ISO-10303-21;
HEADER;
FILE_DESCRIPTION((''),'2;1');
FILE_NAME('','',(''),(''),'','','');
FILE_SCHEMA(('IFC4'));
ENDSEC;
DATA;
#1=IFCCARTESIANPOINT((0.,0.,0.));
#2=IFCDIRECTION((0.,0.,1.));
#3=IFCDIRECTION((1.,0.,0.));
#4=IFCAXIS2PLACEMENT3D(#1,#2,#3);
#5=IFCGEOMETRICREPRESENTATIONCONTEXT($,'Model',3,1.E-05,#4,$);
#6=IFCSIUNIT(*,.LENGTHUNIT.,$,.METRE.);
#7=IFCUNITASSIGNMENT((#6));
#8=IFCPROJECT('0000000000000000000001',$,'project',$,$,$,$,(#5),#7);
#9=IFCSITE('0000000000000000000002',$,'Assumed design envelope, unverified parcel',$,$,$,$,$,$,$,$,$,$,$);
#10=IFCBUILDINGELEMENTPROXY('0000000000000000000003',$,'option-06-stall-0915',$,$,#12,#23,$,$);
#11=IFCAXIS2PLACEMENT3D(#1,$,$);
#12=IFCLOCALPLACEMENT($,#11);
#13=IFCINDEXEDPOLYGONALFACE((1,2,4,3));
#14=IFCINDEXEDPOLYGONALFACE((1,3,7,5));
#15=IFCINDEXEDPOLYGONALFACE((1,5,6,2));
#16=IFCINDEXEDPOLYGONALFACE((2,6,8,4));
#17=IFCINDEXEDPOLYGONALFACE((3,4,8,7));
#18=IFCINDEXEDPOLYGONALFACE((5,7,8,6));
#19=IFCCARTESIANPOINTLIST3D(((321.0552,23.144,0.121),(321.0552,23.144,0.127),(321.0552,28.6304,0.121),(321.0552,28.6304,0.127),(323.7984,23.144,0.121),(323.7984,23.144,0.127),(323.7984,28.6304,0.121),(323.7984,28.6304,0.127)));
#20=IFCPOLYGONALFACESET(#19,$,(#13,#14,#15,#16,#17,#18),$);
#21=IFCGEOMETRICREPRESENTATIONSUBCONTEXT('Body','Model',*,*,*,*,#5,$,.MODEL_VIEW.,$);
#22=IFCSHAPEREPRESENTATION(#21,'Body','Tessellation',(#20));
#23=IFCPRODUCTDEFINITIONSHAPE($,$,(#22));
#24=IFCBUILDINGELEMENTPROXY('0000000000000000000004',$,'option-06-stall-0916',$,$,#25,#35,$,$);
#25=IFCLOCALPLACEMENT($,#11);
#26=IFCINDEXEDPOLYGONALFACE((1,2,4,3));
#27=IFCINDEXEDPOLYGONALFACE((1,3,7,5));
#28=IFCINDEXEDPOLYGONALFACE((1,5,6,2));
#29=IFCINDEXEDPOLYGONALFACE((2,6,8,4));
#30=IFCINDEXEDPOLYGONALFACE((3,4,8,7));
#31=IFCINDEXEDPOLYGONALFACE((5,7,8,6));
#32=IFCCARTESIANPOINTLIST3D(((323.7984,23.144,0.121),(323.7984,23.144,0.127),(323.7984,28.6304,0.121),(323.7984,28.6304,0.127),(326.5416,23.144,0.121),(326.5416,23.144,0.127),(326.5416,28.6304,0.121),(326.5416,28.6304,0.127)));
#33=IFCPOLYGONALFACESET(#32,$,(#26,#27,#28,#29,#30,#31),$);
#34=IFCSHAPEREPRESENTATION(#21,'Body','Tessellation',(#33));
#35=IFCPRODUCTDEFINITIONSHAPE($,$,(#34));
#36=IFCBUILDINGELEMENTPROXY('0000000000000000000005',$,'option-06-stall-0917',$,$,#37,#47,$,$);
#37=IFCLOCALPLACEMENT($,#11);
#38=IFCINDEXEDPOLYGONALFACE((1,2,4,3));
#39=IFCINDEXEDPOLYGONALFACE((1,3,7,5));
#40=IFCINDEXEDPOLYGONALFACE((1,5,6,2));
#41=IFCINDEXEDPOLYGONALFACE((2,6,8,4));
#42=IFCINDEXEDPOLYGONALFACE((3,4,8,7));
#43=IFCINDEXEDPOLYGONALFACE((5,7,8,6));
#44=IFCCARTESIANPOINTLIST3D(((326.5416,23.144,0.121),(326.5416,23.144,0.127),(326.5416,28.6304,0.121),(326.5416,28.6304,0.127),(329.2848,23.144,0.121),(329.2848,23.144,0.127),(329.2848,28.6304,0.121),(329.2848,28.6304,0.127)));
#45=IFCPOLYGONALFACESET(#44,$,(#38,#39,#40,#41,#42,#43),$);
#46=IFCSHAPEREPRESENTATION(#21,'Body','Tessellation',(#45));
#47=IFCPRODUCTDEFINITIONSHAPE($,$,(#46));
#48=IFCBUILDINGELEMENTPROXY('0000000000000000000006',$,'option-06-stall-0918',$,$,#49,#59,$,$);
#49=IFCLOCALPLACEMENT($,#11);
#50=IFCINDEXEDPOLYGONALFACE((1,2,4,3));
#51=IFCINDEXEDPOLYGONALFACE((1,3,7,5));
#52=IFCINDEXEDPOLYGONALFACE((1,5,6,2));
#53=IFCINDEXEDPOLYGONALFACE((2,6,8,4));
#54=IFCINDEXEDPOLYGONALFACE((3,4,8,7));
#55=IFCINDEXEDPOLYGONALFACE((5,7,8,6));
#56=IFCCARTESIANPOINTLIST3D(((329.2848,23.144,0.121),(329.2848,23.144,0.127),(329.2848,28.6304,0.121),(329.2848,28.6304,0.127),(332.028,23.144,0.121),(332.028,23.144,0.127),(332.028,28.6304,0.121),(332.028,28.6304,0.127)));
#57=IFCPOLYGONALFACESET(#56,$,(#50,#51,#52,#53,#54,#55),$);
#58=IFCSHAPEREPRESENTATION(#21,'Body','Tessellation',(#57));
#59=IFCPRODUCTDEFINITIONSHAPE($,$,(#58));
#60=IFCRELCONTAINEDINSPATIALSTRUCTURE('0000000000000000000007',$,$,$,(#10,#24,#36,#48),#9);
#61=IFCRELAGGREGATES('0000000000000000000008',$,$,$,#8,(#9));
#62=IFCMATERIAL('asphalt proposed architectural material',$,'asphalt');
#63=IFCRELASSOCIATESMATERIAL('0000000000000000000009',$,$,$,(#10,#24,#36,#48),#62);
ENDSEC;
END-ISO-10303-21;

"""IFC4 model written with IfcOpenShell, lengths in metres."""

from ifc_helpers import new_model, si_unit, frame, origin_with_axes, place, context, subcontext, project, spatial, rectangle, extrude, material, element, save


model = new_model("IFC4")

# Units and contexts
model_context = context("Model", 3, precision=1e-05, world=origin_with_axes())
body_context = subcontext(model_context, "Body", "Model", "MODEL_VIEW")
ifc_project = project(units=[si_unit("LENGTHUNIT", "METRE")], contexts=[model_context])

# Site
site = spatial("IfcSite", under=ifc_project, Name="Assumed design envelope, unverified parcel")

# Building element proxies
ifc_material = material(Name="asphalt proposed architectural material", Category="asphalt")
for number, where, z_axis, x_axis, name in (
    (1, (322.4268, 25.8872, 0.121), (0.0, 0.0, 1.0), (1.0, 0.0, 0.0), "option-06-stall-0915"),
    (2, (325.17, 25.8872, 0.121), (0.0, 0.0, 1.0), (1.0, 0.0, 0.0), "option-06-stall-0916"),
    (3, (327.9132, 25.8872, 0.121), (0.0, 0.0, 1.0), (1.0, 0.0, 0.0), "option-06-stall-0917"),
    (4, (330.6564, 25.8872, 0.121), (0.0, 0.0, 1.0), (1.0, 0.0, 0.0), "option-06-stall-0918"),
):
    element("IfcBuildingElementProxy", number, at=place(None, frame(where, z_axis=z_axis, x_axis=x_axis)), inside=site, material=ifc_material, Name=name, context=body_context, shape_type="SweptSolid", body=[
        extrude(rectangle(XDim=2.7432, YDim=5.4864), origin_with_axes(), (0.0, 0.0, 1.0), 0.006),
    ])

save(model, "model.ifc")
